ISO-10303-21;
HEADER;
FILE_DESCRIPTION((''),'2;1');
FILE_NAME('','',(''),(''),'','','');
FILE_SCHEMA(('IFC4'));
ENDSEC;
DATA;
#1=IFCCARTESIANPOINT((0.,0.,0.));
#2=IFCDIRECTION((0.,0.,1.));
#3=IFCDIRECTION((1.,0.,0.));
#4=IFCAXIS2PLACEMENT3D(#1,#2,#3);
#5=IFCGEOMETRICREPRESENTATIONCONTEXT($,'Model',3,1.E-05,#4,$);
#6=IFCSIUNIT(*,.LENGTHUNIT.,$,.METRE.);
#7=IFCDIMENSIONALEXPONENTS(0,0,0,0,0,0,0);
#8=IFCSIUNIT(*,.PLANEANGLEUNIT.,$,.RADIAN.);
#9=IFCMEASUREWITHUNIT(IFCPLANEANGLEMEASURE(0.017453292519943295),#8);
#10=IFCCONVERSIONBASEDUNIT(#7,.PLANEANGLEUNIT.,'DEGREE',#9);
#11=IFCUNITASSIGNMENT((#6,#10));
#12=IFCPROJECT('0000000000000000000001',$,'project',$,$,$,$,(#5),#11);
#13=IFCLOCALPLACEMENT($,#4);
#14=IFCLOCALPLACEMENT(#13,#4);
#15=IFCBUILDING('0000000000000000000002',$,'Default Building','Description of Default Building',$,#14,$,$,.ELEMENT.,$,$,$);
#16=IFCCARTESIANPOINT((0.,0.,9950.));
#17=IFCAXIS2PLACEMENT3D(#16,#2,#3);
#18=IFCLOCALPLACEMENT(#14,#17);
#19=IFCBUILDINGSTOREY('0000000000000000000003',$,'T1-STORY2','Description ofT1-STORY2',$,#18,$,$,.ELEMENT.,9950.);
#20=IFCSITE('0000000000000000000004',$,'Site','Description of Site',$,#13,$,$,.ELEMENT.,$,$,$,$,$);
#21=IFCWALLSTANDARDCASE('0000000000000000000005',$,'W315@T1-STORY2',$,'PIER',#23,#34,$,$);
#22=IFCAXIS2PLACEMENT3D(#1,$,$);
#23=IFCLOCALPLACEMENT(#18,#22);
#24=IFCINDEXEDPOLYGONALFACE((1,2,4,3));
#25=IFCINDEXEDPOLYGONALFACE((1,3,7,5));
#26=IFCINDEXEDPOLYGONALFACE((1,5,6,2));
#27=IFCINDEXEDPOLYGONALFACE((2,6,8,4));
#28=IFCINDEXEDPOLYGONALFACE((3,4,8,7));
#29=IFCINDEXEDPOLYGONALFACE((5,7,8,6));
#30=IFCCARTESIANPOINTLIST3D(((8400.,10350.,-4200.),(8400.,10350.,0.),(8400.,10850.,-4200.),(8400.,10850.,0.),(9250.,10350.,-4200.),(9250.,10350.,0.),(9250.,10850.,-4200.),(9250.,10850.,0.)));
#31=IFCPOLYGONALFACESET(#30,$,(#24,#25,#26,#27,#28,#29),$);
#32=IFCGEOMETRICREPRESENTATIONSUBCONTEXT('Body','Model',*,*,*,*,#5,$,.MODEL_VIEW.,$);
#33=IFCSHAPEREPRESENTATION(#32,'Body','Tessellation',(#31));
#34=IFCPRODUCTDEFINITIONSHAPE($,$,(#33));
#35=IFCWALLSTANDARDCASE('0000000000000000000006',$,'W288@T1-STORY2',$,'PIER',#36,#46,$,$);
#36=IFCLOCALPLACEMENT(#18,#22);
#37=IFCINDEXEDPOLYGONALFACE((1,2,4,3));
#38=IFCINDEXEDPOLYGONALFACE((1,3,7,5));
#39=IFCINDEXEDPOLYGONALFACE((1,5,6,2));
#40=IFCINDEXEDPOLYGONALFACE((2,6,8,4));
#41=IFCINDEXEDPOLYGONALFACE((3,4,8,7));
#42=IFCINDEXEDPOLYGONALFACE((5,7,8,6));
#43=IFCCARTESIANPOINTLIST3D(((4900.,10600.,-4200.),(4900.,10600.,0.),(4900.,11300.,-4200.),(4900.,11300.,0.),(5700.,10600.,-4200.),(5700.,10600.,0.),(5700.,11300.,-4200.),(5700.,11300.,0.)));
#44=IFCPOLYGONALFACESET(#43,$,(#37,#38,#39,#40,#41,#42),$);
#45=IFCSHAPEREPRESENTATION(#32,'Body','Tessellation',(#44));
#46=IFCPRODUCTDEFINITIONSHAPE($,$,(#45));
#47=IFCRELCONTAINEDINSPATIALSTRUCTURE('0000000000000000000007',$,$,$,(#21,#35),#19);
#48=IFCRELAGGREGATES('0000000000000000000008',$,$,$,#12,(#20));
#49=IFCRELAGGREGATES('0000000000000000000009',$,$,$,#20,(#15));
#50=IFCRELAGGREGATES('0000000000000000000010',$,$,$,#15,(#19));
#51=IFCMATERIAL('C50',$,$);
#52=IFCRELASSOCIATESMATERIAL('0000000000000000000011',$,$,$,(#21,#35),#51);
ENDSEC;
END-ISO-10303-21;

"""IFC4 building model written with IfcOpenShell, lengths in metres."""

from ifc_helpers import new_model, entity, si_unit, converted_unit, frame, origin_with_axes, place, context, subcontext, project, spatial, indexed_curve, outline, extrude, material, element, save


model = new_model("IFC4")

# Units and contexts
model_context = context("Model", 3, precision=1e-05, world=origin_with_axes())
body_context = subcontext(model_context, "Body", "Model", "MODEL_VIEW")
ifc_project = project(units=[si_unit("LENGTHUNIT", "METRE"), converted_unit("PLANEANGLEUNIT", "DEGREE", entity("IfcPlaneAngleMeasure", 0.017453292519943295), si_unit("PLANEANGLEUNIT", "RADIAN"), dimensions=[0, 0, 0, 0, 0, 0, 0])], contexts=[model_context])

# Site, building, storey
site_placement = place(None, origin_with_axes())
site = spatial("IfcSite", under=ifc_project, at=site_placement, Name="Site", Description="Description of Site", CompositionType="ELEMENT")
building_placement = place(site_placement, origin_with_axes())
building = spatial("IfcBuilding", under=site, at=building_placement, Name="Default Building", Description="Description of Default Building", CompositionType="ELEMENT")
storey_placement = place(building_placement, frame((0.0, 0.0, 9950.0), z_axis=(0.0, 0.0, 1.0), x_axis=(1.0, 0.0, 0.0)))
storey = spatial("IfcBuildingStorey", under=building, at=storey_placement, Name="T1-STORY2", Description="Description ofT1-STORY2", CompositionType="ELEMENT", Elevation=9950.0)

# Shared definitions
ifc_material_1 = material(Name="C50")

# Walls
wall_1_placement = place(storey_placement, frame((8400.0, 10600.0, -4200.0), z_axis=(0.0, 0.0, 1.0), x_axis=(1.0, 0.0, 0.0)))
element("IfcWallStandardCase", 1, at=wall_1_placement, inside=storey, material=ifc_material_1, Name="W315@T1-STORY2", ObjectType="PIER", context=body_context, shape_type="SweptSolid", body=[
    extrude(outline(indexed_curve([(0.0, -250.0), (0.0, 250.0), (850.0, 250.0), (850.0, -250.0), (0.0, -250.0)], self_intersect=False)), origin_with_axes(), (0.0, 0.0, 1.0), 4200.0),
])
wall_2_placement = place(storey_placement, frame((5300.0, 10600.0, -4200.0), z_axis=(0.0, 0.0, 1.0), x_axis=(0.0, 1.0, 0.0)))
element("IfcWallStandardCase", 2, at=wall_2_placement, inside=storey, material=ifc_material_1, Name="W288@T1-STORY2", ObjectType="PIER", context=body_context, shape_type="SweptSolid", body=[
    extrude(outline(indexed_curve([(0.0, -400.0), (0.0, 400.0), (700.0, 400.0), (700.0, -400.0), (0.0, -400.0)], self_intersect=False)), origin_with_axes(), (0.0, 0.0, 1.0), 4200.0),
])

save(model, "model.ifc")
